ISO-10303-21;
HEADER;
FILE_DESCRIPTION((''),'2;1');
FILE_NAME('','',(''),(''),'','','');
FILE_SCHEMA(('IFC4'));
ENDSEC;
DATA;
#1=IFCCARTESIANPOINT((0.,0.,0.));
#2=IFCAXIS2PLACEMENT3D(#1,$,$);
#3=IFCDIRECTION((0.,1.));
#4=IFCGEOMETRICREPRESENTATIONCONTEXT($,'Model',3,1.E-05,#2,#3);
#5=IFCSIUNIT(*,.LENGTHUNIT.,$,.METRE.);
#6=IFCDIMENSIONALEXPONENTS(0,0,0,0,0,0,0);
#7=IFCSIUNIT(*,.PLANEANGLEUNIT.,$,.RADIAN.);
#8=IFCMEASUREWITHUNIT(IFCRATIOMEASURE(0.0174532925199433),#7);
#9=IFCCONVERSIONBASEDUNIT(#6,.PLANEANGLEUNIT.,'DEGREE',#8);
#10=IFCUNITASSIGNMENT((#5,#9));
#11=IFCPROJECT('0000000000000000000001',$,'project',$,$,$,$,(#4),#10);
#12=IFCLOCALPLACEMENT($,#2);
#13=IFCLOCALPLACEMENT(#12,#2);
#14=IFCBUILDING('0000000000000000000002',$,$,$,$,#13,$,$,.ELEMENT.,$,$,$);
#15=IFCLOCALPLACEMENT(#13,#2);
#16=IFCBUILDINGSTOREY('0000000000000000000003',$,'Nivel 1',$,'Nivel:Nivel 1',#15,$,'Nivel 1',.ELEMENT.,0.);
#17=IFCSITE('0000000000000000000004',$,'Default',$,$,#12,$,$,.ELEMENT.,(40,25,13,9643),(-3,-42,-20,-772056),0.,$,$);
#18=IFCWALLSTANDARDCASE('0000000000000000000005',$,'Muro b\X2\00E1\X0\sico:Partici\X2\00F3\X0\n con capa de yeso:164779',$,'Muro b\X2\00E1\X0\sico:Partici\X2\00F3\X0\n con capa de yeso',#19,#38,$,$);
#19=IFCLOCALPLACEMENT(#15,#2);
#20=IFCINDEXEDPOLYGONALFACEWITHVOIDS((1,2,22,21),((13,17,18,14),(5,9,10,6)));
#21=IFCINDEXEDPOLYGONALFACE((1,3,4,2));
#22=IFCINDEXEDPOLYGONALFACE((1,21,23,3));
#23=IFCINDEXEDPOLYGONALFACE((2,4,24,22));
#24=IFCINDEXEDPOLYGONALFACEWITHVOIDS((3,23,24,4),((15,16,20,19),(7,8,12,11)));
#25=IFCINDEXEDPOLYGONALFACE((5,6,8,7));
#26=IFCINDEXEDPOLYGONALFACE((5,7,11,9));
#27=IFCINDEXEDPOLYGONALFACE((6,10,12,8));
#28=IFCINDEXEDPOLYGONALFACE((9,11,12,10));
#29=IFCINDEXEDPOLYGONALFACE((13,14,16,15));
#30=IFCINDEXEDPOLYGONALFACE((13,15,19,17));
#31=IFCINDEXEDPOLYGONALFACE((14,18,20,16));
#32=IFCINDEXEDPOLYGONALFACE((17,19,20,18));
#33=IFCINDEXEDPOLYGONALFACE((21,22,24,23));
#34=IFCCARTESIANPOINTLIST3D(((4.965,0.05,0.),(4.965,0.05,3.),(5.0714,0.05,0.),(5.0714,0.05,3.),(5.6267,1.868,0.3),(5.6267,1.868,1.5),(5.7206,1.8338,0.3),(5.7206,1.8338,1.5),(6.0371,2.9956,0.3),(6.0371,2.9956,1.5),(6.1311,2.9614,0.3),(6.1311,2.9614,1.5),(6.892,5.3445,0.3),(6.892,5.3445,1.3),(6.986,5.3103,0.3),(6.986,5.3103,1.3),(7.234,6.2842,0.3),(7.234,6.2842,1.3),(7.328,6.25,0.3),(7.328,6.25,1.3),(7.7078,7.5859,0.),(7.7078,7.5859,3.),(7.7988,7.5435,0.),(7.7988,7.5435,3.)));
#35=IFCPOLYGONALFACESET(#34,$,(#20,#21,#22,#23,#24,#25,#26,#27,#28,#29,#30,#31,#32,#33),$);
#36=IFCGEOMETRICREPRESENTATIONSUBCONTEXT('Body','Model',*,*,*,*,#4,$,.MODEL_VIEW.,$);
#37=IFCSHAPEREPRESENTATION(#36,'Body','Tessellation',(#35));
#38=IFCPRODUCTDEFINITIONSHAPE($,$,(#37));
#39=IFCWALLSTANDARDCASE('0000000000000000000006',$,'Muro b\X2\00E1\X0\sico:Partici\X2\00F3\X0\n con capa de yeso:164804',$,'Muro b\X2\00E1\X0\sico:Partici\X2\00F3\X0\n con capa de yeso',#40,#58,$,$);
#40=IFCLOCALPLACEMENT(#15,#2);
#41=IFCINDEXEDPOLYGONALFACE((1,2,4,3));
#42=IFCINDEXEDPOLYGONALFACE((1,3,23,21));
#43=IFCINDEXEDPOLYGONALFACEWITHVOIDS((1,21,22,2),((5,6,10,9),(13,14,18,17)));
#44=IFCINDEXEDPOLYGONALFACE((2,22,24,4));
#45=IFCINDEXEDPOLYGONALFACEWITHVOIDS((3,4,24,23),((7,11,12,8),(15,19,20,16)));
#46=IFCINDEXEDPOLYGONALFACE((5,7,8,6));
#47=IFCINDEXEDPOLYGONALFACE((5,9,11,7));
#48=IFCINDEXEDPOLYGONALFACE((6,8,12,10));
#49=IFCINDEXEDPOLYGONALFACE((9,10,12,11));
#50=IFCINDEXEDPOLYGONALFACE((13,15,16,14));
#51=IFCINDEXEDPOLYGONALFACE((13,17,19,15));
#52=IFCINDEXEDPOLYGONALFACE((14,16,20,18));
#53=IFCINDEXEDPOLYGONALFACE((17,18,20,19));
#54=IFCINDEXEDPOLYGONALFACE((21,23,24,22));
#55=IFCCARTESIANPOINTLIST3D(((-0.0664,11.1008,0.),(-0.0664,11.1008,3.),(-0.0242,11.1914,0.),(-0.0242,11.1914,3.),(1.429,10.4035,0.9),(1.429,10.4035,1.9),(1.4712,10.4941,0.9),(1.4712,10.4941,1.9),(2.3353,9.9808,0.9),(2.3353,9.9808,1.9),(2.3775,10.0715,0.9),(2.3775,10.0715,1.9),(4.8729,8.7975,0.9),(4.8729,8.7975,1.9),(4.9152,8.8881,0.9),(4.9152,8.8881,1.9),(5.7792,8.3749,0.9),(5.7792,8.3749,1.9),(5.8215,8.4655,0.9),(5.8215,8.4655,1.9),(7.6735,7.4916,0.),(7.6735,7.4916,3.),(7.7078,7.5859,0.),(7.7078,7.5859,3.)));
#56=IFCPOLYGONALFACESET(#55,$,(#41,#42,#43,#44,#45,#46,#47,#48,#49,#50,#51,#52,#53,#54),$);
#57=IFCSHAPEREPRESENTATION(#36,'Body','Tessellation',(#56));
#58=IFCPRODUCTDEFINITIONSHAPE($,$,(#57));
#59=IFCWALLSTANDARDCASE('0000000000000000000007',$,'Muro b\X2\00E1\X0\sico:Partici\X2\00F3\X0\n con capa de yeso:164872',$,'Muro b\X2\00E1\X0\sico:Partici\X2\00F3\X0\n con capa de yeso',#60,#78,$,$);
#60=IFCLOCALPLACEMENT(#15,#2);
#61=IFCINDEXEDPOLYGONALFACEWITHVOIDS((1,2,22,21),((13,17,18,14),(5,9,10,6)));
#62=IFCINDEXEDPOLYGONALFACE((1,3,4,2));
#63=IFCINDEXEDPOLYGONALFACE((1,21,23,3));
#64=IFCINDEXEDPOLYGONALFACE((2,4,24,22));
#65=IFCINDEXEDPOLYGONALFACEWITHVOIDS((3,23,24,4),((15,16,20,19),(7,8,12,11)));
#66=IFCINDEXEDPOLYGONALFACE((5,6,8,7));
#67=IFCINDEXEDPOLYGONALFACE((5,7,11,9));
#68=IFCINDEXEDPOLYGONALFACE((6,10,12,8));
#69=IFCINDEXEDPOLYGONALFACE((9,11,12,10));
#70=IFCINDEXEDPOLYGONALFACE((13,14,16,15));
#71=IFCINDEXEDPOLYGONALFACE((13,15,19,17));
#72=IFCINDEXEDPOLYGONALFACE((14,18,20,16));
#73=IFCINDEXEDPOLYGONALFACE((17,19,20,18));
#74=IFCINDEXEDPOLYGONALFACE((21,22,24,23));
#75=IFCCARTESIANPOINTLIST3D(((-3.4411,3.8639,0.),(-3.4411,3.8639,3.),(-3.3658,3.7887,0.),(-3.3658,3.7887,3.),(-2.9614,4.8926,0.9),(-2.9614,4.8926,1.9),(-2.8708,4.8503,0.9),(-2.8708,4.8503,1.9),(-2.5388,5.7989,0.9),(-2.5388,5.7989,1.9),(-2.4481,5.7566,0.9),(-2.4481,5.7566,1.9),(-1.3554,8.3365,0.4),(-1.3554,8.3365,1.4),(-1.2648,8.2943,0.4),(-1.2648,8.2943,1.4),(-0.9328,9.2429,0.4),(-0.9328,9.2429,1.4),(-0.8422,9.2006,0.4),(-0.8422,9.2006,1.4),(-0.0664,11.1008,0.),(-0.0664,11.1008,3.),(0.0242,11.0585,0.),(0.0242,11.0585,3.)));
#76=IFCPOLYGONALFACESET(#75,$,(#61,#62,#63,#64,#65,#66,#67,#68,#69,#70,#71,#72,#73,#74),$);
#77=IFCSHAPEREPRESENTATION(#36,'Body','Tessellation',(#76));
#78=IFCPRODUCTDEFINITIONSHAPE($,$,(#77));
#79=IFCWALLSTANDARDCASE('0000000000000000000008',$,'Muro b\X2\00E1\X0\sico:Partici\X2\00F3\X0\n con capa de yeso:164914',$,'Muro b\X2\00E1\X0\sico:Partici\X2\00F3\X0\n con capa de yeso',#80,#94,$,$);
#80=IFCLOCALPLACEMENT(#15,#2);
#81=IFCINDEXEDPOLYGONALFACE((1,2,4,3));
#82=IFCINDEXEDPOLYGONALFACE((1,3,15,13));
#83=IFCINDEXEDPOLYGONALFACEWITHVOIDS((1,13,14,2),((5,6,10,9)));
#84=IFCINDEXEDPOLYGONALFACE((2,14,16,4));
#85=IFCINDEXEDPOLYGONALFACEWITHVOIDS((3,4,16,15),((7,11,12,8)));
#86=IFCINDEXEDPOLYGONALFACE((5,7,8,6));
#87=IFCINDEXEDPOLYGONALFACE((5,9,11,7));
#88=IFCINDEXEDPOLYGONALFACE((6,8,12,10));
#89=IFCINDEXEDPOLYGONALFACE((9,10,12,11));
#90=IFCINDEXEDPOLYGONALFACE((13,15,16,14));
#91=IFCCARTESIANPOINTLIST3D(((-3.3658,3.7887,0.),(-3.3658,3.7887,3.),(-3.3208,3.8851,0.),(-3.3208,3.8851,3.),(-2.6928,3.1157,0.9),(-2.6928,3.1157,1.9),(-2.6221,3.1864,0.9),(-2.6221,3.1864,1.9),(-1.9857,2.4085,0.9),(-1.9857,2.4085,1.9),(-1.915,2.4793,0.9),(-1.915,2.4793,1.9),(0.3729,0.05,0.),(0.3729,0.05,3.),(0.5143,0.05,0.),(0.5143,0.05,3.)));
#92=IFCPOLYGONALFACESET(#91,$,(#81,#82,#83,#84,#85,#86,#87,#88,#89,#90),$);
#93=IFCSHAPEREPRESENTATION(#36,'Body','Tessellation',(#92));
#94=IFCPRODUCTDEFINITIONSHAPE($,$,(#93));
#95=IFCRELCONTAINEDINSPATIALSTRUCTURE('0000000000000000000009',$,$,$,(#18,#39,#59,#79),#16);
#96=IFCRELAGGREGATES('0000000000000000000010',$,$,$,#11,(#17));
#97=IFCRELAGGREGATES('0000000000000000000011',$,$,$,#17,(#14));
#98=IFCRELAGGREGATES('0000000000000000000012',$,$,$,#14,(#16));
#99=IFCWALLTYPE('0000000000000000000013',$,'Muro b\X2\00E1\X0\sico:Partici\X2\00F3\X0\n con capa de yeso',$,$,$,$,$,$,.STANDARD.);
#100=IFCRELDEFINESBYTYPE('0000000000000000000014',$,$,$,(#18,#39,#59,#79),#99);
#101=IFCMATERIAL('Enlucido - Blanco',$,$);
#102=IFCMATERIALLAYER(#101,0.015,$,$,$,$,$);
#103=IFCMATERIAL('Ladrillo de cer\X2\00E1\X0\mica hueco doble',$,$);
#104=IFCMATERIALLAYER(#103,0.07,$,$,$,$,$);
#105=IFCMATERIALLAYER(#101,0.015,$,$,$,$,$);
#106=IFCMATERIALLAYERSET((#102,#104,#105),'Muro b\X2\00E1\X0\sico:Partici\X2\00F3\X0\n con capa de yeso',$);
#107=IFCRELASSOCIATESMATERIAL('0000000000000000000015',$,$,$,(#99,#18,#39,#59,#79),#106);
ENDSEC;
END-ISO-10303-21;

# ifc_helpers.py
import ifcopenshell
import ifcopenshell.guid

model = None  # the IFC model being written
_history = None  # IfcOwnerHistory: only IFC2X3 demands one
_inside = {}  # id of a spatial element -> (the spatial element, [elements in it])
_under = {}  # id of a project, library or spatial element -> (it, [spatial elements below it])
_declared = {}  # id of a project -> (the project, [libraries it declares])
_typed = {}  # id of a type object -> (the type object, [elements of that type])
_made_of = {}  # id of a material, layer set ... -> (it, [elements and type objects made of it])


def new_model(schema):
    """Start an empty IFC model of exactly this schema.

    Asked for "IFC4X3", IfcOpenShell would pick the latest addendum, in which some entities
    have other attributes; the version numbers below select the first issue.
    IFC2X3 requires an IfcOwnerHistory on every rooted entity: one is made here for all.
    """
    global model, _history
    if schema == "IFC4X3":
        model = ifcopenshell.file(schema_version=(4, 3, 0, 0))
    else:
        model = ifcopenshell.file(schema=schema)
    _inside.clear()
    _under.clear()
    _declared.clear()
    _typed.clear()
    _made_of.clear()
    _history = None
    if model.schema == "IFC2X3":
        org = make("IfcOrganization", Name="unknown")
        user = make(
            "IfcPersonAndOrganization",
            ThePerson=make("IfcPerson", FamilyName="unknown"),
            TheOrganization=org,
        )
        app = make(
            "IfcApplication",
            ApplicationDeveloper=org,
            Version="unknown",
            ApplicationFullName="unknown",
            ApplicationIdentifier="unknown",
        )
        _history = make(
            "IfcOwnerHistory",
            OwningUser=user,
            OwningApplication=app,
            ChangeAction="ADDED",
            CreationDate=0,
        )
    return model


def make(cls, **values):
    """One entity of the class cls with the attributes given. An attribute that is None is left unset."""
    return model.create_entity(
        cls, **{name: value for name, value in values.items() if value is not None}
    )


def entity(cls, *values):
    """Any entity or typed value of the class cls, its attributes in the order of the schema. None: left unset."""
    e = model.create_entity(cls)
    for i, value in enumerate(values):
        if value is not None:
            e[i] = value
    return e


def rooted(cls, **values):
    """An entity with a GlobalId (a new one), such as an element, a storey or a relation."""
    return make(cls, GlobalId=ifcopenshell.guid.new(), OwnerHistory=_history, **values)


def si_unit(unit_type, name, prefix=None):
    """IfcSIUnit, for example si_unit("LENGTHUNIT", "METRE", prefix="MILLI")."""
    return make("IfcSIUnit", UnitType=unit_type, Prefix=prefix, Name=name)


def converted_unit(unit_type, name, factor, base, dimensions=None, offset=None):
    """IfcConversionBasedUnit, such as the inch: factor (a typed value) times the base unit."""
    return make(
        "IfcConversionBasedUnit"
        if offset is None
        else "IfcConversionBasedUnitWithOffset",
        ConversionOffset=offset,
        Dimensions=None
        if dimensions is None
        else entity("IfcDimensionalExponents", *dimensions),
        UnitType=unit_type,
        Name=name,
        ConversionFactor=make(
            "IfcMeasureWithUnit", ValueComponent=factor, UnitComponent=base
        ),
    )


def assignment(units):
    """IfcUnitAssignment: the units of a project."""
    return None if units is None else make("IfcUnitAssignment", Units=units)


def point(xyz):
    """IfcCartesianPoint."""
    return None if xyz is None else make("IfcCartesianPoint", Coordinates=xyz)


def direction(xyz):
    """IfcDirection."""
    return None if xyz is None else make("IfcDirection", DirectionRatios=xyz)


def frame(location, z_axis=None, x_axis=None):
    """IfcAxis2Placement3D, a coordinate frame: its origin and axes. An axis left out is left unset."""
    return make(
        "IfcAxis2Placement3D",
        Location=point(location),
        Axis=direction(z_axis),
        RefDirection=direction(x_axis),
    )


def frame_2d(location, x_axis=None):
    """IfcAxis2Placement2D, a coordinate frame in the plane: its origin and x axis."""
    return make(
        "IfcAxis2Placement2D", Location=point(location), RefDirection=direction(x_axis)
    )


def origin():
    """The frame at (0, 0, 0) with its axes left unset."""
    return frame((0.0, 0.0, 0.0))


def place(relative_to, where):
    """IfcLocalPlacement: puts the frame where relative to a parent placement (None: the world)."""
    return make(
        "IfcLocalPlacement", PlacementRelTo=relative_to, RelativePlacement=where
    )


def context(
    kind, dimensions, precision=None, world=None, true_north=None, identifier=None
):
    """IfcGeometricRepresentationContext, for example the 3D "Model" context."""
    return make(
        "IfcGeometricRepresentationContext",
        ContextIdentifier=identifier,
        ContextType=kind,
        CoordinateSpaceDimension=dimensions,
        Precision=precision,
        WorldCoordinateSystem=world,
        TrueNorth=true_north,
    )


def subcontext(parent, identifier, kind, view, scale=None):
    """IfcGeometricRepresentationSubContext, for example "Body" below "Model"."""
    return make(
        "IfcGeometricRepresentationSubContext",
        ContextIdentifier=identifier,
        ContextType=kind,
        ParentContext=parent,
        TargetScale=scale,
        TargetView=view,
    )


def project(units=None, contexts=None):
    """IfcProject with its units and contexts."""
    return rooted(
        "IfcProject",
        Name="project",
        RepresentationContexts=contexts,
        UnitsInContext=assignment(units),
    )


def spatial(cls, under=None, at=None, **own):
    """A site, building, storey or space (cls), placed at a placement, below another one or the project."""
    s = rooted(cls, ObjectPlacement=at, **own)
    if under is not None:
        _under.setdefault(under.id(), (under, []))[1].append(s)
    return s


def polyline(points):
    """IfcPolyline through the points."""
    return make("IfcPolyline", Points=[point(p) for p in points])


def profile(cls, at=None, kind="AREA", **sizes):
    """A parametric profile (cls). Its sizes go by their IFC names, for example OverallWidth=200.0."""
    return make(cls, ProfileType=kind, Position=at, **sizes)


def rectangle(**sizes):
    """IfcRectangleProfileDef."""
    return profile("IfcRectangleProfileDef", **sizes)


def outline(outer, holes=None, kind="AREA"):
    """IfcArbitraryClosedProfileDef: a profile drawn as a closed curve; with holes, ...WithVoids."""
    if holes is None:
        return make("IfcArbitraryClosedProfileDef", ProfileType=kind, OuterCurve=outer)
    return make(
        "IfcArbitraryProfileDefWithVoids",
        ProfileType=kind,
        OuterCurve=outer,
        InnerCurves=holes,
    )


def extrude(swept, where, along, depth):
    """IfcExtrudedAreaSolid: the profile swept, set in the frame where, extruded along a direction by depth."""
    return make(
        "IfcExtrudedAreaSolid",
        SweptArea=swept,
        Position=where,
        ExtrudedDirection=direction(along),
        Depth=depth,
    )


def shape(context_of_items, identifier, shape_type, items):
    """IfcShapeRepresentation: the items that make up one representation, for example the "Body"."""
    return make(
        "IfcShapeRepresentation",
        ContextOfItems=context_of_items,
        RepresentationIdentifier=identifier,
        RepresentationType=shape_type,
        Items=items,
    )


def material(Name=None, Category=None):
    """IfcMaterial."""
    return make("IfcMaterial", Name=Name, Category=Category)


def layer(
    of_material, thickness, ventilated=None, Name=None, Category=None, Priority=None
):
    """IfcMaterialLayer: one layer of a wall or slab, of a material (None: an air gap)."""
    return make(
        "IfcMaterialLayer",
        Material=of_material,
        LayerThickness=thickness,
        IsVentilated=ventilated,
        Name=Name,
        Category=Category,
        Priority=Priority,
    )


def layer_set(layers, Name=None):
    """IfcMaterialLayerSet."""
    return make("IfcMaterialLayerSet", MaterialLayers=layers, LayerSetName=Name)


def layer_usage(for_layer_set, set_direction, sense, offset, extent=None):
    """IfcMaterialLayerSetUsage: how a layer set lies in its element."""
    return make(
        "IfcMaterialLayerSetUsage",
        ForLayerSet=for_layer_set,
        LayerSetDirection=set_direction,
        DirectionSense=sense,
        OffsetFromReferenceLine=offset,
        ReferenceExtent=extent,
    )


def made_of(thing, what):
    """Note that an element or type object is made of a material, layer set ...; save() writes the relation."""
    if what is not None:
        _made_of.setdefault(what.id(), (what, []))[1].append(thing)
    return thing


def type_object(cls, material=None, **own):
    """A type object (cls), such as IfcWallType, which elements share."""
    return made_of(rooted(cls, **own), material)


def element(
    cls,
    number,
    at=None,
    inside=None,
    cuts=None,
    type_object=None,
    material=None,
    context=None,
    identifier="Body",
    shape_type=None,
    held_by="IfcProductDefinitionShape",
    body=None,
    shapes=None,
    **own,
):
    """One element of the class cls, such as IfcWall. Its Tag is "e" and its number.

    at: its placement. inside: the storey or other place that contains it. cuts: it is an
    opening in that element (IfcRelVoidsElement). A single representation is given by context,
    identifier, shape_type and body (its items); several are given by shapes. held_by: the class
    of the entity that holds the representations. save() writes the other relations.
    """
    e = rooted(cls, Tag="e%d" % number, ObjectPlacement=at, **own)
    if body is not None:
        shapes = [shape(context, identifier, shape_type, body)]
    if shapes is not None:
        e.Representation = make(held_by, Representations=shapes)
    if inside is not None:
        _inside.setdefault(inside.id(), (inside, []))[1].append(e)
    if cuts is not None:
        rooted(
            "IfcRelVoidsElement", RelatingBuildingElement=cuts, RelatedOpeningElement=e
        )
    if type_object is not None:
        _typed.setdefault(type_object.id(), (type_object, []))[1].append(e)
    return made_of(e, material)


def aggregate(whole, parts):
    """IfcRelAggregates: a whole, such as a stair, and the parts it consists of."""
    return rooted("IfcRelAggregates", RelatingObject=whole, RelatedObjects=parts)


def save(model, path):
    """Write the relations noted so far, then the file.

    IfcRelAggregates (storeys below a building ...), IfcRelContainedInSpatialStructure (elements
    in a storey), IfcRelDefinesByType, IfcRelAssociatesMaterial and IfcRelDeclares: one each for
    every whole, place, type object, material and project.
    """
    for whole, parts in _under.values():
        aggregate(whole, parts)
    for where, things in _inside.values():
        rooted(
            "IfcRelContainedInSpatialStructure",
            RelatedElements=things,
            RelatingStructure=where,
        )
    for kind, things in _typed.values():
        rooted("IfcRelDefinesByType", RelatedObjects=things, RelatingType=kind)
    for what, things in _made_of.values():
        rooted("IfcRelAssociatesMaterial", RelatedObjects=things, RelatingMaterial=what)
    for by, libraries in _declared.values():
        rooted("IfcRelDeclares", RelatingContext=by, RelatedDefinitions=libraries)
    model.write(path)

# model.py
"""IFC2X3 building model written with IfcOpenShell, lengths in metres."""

from ifc_helpers import new_model, entity, si_unit, converted_unit, direction, frame, frame_2d, origin, place, context, subcontext, project, spatial, polyline, rectangle, outline, extrude, material, layer, layer_set, layer_usage, type_object, element, save


model = new_model("IFC2X3")

# Units and contexts
model_context = context("Model", 3, precision=1e-05, world=origin(), true_north=direction((0.0, 1.0)))
body_context = subcontext(model_context, "Body", "Model", "MODEL_VIEW")
ifc_project = project(units=[si_unit("LENGTHUNIT", "METRE"), converted_unit("PLANEANGLEUNIT", "DEGREE", entity("IfcRatioMeasure", 0.0174532925199433), si_unit("PLANEANGLEUNIT", "RADIAN"), dimensions=[0, 0, 0, 0, 0, 0, 0])], contexts=[model_context])

# Site, building, storey
site_placement = place(None, origin())
site = spatial("IfcSite", under=ifc_project, at=site_placement, Name="Default", CompositionType="ELEMENT", RefLatitude=(40, 25, 13, 9643), RefLongitude=(-3, -42, -20, -772056), RefElevation=0.0)
building_placement = place(site_placement, origin())
building = spatial("IfcBuilding", under=site, at=building_placement, CompositionType="ELEMENT")
storey_placement = place(building_placement, origin())
storey = spatial("IfcBuildingStorey", under=building, at=storey_placement, Name="Nivel 1", ObjectType="Nivel:Nivel 1", LongName="Nivel 1", CompositionType="ELEMENT", Elevation=0.0)

# Walls, openings
ifc_material_1 = material(Name="Enlucido - Blanco")
ifc_layer_1 = layer(ifc_material_1, 0.015)
ifc_material_2 = material(Name="Ladrillo de cerámica hueco doble")
ifc_layer_2 = layer(ifc_material_2, 0.07)
ifc_layer_3 = layer(ifc_material_1, 0.015)
ifc_layer_set = layer_set([ifc_layer_1, ifc_layer_2, ifc_layer_3], Name="Muro básico:Partición con capa de yeso")
wall_type = type_object("IfcWallType", Name="Muro básico:Partición con capa de yeso", PredefinedType="STANDARD", material=ifc_layer_set)
ifc_layer_usage_1 = layer_usage(ifc_layer_set, "AXIS2", "NEGATIVE", 0.05)
wall_1_placement = place(storey_placement, frame((5.012, 0.0329, 0.0), z_axis=(0.0, 0.0, 1.0), x_axis=(0.34202, 0.939693, 0.0)))
wall_1 = element("IfcWallStandardCase", 1, at=wall_1_placement, inside=storey, type_object=wall_type, material=ifc_layer_usage_1, Name="Muro básico:Partición con capa de yeso:164779", ObjectType="Muro básico:Partición con capa de yeso", context=body_context, shape_type="SweptSolid", body=[
    extrude(outline(polyline([(8.0108, -0.05), (8.0196, 0.05), (7.9192, 0.05), (0.0, 0.05), (0.0364, -0.05), (8.0108, -0.05)])), origin(), (0.0, 0.0, 1.0), 3.0),
])
opening_1_placement = place(wall_1_placement, frame((6.6343, 0.05, 0.3)))
element("IfcOpeningElement", 2, at=opening_1_placement, cuts=wall_1, ObjectType="Opening", context=body_context, shape_type="SweptSolid", body=[
    extrude(rectangle(XDim=1.0, YDim=1.0, at=frame_2d((0.5, 0.5), x_axis=(1.0, 0.0))), frame((0.0, 0.0, 0.0), z_axis=(0.0, -1.0, 0.0), x_axis=(0.0, 0.0, 1.0)), (0.0, 0.0, 1.0), 0.1),
])
opening_2_placement = place(wall_1_placement, frame((3.1346, 0.05, 0.3)))
element("IfcOpeningElement", 3, at=opening_2_placement, cuts=wall_1, ObjectType="Opening", context=body_context, shape_type="SweptSolid", body=[
    extrude(rectangle(XDim=1.2, YDim=1.2, at=frame_2d((0.6, 0.6), x_axis=(1.0, 0.0))), frame((0.0, 0.0, 0.0), z_axis=(0.0, -1.0, 0.0), x_axis=(0.0, 0.0, 1.0)), (0.0, 0.0, 1.0), 0.1),
])
ifc_layer_usage_2 = layer_usage(ifc_layer_set, "AXIS2", "NEGATIVE", 0.05)
wall_2_placement = place(storey_placement, frame((7.6946, 7.5369, 0.0), z_axis=(0.0, 0.0, 1.0), x_axis=(-0.906308, 0.422618, 0.0)))
wall_2 = element("IfcWallStandardCase", 4, at=wall_2_placement, inside=storey, type_object=wall_type, material=ifc_layer_usage_2, Name="Muro básico:Partición con capa de yeso:164804", ObjectType="Muro básico:Partición con capa de yeso", context=body_context, shape_type="SweptSolid", body=[
    extrude(outline(polyline([(8.5401, -0.05), (8.5401, 0.05), (8.4401, 0.05), (0.0, 0.05), (0.0087, -0.05), (8.5401, -0.05)])), origin(), (0.0, 0.0, 1.0), 3.0),
])
opening_3_placement = place(wall_2_placement, frame((3.0901, 0.05, 0.9)))
element("IfcOpeningElement", 5, at=opening_3_placement, cuts=wall_2, ObjectType="Opening", context=body_context, shape_type="SweptSolid", body=[
    extrude(rectangle(XDim=1.0, YDim=1.0, at=frame_2d((0.5, 0.5), x_axis=(1.0, 0.0))), frame((0.0, 0.0, 0.0), z_axis=(0.0, -1.0, 0.0), x_axis=(0.0, 0.0, 1.0)), (0.0, 0.0, 1.0), 0.1),
])
opening_4_placement = place(wall_2_placement, frame((6.8901, 0.05, 0.9)))
element("IfcOpeningElement", 6, at=opening_4_placement, cuts=wall_2, ObjectType="Opening", context=body_context, shape_type="SweptSolid", body=[
    extrude(rectangle(XDim=1.0, YDim=1.0, at=frame_2d((0.5, 0.5), x_axis=(1.0, 0.0))), frame((0.0, 0.0, 0.0), z_axis=(0.0, -1.0, 0.0), x_axis=(0.0, 0.0, 1.0)), (0.0, 0.0, 1.0), 0.1),
])
ifc_layer_usage_3 = layer_usage(ifc_layer_set, "AXIS2", "NEGATIVE", 0.05)
wall_3_placement = place(storey_placement, frame((-0.0211, 11.0797, 0.0), z_axis=(0.0, 0.0, 1.0), x_axis=(-0.422618, -0.906308, 0.0)))
wall_3 = element("IfcWallStandardCase", 7, at=wall_3_placement, inside=storey, type_object=wall_type, material=ifc_layer_usage_3, Name="Muro básico:Partición con capa de yeso:164872", ObjectType="Muro básico:Partición con capa de yeso", context=body_context, shape_type="SweptSolid", body=[
    extrude(outline(polyline([(7.985, -0.05), (8.0214, 0.05), (7.915, 0.05), (0.0, 0.05), (0.0, -0.05), (7.985, -0.05)])), origin(), (0.0, 0.0, 1.0), 3.0),
])
opening_5_placement = place(wall_3_placement, frame((3.05, 0.05, 0.4)))
element("IfcOpeningElement", 8, at=opening_5_placement, cuts=wall_3, ObjectType="Opening", context=body_context, shape_type="SweptSolid", body=[
    extrude(rectangle(XDim=1.0, YDim=1.0, at=frame_2d((0.5, 0.5), x_axis=(1.0, 0.0))), frame((0.0, 0.0, 0.0), z_axis=(0.0, -1.0, 0.0), x_axis=(0.0, 0.0, 1.0)), (0.0, 0.0, 1.0), 0.1),
])
opening_6_placement = place(wall_3_placement, frame((6.85, 0.05, 0.9)))
element("IfcOpeningElement", 9, at=opening_6_placement, cuts=wall_3, ObjectType="Opening", context=body_context, shape_type="SweptSolid", body=[
    extrude(rectangle(XDim=1.0, YDim=1.0, at=frame_2d((0.5, 0.5), x_axis=(1.0, 0.0))), frame((0.0, 0.0, 0.0), z_axis=(0.0, -1.0, 0.0), x_axis=(0.0, 0.0, 1.0)), (0.0, 0.0, 1.0), 0.1),
])

# Wall, opening
ifc_layer_usage_4 = layer_usage(ifc_layer_set, "AXIS2", "NEGATIVE", 0.05)
wall_4_placement = place(storey_placement, frame((-3.3562, 3.8498, 0.0), z_axis=(0.0, 0.0, 1.0), x_axis=(0.707107, -0.707107, 0.0)))
wall_4 = element("IfcWallStandardCase", 10, at=wall_4_placement, inside=storey, type_object=wall_type, material=ifc_layer_usage_4, Name="Muro básico:Partición con capa de yeso:164914", ObjectType="Muro básico:Partición con capa de yeso", context=body_context, shape_type="SweptSolid", body=[
    extrude(outline(polyline([(5.3237, -0.05), (5.4237, 0.05), (0.0, 0.05), (0.0364, -0.05), (5.3237, -0.05)])), origin(), (0.0, 0.0, 1.0), 3.0),
])
opening_7_placement = place(wall_4_placement, frame((1.9882, 0.05, 0.9)))
element("IfcOpeningElement", 11, at=opening_7_placement, cuts=wall_4, ObjectType="Opening", context=body_context, shape_type="SweptSolid", body=[
    extrude(rectangle(XDim=1.0, YDim=1.0, at=frame_2d((0.5, 0.5), x_axis=(1.0, 0.0))), frame((0.0, 0.0, 0.0), z_axis=(0.0, -1.0, 0.0), x_axis=(0.0, 0.0, 1.0)), (0.0, 0.0, 1.0), 0.1),
])

save(model, "model.ifc")
